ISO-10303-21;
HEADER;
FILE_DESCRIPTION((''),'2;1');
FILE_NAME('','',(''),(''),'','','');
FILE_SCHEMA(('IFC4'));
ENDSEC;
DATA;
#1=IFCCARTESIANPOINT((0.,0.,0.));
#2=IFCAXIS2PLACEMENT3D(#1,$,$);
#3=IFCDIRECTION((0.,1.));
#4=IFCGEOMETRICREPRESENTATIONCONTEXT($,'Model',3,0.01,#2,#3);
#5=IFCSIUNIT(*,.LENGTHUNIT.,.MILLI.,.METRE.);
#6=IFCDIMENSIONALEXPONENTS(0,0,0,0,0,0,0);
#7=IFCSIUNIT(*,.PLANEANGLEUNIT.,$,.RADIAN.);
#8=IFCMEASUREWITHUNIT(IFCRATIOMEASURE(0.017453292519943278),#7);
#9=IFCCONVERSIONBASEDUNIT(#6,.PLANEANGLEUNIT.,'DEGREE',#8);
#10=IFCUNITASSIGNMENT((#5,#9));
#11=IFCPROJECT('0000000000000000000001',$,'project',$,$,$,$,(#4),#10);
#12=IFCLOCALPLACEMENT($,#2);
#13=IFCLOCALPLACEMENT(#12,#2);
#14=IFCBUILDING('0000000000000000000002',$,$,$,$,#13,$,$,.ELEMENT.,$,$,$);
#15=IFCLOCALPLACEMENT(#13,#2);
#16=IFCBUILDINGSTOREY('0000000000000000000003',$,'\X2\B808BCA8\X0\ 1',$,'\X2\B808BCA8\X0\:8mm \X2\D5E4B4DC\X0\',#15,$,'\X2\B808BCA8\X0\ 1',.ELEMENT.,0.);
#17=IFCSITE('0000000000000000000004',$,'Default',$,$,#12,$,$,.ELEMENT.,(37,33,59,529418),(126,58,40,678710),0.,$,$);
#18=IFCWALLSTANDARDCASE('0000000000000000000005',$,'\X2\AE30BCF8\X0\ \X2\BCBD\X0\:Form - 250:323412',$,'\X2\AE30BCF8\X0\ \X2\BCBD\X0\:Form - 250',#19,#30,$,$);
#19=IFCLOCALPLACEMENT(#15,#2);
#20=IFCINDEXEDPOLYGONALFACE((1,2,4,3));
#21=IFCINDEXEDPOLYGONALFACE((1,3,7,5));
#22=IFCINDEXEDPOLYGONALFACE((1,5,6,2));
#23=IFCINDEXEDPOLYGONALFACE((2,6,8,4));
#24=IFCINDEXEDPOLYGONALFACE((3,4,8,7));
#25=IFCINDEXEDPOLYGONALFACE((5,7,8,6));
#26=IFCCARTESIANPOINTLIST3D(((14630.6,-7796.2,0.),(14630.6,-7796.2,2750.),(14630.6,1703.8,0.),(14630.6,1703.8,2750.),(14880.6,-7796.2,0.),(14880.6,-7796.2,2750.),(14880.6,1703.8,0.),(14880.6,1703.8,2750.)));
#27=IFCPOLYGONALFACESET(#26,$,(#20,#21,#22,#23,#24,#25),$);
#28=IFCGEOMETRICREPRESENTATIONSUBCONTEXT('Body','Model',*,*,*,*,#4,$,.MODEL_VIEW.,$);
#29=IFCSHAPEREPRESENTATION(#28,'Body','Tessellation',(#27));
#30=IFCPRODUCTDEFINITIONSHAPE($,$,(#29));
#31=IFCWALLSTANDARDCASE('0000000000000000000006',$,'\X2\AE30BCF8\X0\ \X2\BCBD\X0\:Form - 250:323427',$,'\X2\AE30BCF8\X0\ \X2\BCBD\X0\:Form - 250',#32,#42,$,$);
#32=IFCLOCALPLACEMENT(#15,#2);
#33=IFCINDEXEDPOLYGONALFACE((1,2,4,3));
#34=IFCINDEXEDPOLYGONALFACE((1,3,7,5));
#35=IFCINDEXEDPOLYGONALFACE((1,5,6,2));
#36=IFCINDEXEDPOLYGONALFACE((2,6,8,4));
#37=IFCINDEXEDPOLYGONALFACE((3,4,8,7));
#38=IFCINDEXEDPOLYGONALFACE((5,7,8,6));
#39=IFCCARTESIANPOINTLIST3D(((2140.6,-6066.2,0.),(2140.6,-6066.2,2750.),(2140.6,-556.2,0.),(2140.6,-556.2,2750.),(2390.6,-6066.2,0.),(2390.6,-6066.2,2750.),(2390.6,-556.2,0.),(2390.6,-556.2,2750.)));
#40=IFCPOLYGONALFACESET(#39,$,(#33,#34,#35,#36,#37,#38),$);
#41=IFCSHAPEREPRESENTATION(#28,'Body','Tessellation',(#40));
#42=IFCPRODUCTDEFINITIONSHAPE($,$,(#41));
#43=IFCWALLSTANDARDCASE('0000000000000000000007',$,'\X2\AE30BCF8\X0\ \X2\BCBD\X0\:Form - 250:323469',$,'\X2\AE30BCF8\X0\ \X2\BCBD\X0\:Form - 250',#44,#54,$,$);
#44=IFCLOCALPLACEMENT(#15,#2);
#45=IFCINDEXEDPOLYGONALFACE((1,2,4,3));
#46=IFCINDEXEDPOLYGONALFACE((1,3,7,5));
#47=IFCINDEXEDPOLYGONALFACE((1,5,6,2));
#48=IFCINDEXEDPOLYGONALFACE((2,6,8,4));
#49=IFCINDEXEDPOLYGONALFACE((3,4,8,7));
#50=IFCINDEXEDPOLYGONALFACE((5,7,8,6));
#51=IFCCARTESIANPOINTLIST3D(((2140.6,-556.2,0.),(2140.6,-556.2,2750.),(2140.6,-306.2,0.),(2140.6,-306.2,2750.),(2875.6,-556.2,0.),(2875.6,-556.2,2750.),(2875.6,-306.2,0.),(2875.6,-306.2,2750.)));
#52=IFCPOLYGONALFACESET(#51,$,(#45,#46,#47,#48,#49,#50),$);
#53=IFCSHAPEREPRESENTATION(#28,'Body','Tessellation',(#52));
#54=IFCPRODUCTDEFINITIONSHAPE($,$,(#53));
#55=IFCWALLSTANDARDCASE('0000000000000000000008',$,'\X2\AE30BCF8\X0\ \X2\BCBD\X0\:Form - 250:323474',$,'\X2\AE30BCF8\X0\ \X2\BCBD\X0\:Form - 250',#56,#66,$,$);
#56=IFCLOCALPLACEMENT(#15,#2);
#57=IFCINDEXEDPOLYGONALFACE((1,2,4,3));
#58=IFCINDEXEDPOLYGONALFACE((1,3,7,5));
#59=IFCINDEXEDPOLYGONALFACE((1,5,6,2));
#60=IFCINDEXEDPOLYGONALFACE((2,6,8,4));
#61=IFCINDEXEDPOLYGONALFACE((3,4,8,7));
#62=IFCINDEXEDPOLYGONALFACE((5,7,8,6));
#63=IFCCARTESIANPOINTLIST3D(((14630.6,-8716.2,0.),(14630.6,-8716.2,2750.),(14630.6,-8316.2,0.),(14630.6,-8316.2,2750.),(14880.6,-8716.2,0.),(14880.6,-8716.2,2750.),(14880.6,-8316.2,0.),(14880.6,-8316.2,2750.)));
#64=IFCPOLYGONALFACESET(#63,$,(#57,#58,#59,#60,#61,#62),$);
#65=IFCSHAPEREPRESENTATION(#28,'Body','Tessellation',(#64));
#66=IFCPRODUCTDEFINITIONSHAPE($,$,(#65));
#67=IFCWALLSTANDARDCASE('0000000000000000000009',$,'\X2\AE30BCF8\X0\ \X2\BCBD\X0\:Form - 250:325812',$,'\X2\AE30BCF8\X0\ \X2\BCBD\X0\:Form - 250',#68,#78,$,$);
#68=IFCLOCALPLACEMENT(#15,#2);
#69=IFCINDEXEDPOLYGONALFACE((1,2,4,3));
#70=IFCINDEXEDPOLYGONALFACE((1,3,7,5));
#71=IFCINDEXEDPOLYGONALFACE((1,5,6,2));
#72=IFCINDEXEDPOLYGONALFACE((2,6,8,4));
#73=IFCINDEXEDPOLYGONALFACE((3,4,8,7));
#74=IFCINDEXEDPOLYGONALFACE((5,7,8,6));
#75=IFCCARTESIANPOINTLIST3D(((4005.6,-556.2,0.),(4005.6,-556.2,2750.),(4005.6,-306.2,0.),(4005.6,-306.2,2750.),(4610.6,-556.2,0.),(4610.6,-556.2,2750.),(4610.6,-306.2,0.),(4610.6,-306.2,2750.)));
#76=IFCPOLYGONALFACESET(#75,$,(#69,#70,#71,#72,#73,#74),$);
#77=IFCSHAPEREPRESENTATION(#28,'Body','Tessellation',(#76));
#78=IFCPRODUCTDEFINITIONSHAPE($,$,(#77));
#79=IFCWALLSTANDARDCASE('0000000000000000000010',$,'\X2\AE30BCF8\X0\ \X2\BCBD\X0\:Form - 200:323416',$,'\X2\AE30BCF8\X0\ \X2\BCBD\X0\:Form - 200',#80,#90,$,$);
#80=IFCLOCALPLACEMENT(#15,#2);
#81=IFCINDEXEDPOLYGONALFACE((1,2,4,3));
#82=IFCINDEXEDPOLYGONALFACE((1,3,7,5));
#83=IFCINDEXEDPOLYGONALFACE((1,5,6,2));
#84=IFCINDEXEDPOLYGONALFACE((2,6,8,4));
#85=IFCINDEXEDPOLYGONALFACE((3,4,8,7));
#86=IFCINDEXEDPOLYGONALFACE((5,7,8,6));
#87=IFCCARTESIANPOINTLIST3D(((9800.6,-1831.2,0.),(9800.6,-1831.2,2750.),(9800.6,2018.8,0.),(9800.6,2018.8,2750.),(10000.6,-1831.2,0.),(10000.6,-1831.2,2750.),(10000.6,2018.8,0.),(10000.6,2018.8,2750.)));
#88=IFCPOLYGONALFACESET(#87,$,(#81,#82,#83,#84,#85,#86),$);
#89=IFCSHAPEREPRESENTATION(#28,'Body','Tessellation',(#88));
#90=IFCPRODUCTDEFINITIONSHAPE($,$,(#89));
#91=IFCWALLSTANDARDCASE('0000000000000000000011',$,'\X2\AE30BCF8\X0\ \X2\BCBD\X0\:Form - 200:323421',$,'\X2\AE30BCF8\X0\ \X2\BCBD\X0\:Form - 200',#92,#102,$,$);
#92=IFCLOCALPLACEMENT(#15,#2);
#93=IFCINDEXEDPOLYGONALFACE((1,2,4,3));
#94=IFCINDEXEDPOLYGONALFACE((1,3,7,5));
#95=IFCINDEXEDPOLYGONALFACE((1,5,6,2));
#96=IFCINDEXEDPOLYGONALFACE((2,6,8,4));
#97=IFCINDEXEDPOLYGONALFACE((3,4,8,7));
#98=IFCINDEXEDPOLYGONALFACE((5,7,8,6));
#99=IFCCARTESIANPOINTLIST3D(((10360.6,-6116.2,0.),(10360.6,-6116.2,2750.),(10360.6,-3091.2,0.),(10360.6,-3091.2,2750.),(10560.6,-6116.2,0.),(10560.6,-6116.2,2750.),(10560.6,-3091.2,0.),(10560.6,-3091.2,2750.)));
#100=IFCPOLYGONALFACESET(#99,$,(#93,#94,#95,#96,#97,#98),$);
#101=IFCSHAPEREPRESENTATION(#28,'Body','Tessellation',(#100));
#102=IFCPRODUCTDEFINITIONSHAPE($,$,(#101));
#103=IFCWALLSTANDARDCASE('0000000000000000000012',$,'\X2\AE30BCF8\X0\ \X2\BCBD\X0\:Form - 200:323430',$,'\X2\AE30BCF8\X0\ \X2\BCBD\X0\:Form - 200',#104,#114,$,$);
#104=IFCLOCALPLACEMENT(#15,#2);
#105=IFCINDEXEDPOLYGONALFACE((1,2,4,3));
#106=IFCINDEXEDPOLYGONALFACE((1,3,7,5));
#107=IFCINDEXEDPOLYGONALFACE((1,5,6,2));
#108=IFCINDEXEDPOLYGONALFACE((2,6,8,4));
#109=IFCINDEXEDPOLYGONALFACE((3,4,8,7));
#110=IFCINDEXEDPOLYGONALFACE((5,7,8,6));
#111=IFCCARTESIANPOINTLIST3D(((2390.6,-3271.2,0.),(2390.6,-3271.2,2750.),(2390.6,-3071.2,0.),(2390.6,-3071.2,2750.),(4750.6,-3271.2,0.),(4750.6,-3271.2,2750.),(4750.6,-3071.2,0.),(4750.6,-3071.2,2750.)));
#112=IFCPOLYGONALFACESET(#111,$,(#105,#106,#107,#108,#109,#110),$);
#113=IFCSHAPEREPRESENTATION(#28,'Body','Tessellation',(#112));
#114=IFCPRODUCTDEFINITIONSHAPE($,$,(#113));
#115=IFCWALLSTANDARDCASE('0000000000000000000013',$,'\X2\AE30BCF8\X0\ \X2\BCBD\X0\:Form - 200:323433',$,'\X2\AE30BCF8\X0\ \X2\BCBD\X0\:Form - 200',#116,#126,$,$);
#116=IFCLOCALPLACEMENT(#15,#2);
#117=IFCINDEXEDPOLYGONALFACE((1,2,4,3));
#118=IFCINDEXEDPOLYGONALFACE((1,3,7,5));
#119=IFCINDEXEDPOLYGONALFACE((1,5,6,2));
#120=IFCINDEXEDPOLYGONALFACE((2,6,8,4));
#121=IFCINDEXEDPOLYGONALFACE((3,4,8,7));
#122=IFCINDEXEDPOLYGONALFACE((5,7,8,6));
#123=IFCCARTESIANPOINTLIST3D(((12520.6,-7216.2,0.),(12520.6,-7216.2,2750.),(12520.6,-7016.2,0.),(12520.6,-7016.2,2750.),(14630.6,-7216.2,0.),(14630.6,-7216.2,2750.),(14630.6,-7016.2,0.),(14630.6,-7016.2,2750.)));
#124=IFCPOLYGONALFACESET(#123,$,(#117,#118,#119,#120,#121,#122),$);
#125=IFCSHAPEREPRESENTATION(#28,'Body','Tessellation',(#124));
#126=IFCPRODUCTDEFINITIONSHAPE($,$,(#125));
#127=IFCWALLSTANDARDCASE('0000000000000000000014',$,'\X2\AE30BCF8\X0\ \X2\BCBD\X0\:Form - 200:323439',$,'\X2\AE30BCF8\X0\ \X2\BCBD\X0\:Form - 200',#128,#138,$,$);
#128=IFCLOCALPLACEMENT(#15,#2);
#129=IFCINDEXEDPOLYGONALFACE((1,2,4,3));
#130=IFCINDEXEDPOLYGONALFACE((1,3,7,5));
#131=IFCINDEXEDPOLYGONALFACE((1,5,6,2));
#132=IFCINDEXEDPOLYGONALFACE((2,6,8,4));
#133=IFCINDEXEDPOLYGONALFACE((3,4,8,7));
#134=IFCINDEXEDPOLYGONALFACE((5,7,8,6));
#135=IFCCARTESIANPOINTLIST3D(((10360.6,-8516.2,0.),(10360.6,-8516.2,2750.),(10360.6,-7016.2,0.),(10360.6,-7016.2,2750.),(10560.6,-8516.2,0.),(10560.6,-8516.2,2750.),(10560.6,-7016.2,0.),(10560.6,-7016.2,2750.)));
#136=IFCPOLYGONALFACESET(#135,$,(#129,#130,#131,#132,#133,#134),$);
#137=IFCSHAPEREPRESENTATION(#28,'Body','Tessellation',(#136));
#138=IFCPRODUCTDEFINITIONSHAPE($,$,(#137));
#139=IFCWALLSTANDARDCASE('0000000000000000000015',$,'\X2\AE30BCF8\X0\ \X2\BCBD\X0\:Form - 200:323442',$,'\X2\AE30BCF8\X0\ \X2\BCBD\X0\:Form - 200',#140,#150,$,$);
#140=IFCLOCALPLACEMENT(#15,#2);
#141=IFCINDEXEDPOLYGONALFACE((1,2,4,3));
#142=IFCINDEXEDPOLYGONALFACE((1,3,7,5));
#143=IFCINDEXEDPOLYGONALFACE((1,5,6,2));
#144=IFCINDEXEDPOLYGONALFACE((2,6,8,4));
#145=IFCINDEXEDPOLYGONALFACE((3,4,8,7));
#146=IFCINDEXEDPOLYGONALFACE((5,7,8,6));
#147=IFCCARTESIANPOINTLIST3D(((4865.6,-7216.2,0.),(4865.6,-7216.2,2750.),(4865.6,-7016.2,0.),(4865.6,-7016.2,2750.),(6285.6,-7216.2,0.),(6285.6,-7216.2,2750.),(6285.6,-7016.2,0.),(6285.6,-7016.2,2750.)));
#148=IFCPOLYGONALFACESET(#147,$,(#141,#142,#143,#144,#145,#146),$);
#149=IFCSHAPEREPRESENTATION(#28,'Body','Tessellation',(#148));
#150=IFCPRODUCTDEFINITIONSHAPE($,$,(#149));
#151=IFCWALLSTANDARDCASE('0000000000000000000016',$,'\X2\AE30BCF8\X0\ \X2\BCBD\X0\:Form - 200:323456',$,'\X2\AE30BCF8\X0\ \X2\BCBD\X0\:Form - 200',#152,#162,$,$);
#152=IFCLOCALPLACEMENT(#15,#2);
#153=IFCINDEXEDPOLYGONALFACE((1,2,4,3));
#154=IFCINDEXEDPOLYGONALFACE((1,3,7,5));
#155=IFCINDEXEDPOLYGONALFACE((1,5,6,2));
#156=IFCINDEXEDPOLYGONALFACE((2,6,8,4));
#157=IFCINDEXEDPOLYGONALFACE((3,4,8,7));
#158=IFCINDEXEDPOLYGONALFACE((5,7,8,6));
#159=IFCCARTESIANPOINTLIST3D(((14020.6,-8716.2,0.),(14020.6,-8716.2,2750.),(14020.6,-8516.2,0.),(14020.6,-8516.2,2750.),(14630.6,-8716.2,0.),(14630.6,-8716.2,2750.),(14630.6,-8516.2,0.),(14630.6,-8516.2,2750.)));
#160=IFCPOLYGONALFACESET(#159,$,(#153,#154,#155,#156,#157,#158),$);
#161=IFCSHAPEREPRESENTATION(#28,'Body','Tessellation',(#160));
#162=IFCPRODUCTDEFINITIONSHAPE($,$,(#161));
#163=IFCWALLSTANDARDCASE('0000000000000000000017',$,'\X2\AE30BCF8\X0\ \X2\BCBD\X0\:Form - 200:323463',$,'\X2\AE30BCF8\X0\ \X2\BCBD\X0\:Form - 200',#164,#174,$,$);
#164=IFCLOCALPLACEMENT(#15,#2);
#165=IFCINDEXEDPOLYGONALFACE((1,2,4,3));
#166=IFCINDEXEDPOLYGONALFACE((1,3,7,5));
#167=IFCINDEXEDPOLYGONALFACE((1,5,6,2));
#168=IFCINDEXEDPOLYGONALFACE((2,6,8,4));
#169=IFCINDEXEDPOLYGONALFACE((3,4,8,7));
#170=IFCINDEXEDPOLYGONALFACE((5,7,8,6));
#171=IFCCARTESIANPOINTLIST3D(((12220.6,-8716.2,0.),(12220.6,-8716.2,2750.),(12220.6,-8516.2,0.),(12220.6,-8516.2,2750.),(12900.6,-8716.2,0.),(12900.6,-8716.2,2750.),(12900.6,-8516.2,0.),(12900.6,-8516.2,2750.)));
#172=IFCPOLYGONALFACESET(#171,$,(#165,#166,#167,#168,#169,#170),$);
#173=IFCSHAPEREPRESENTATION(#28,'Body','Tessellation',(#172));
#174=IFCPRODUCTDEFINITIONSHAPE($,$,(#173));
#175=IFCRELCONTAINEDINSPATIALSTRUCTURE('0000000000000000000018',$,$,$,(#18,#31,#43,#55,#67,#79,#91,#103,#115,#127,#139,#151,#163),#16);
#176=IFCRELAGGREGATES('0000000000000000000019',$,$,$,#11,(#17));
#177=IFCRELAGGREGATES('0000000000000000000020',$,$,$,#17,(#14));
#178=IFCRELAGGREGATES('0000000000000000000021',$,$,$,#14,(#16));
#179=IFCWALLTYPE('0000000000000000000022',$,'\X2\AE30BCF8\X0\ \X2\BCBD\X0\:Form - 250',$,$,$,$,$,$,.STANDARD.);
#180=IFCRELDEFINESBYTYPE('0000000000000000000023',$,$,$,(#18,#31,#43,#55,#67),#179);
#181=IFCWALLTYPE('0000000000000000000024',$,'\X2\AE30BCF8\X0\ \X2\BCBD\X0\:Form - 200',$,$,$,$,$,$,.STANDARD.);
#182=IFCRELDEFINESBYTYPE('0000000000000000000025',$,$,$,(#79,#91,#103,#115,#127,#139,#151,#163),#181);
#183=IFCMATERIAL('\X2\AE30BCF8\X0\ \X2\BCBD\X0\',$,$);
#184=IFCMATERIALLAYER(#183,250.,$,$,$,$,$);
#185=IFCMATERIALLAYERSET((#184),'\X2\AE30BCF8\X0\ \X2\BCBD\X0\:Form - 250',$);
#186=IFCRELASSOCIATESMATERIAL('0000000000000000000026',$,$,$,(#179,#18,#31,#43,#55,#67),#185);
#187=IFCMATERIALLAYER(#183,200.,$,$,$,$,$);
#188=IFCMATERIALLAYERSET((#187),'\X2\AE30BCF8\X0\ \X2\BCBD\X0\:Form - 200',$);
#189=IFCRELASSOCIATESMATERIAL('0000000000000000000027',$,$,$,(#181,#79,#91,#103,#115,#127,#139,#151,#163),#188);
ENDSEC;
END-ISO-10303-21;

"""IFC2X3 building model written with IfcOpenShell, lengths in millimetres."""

from ifc_helpers import new_model, entity, si_unit, converted_unit, direction, frame, frame_2d, origin, place, context, subcontext, project, spatial, rectangle, extrude, material, layer, layer_set, layer_usage, type_object, element, save


model = new_model("IFC2X3")

# Units and contexts
model_context = context("Model", 3, precision=0.01, world=origin(), true_north=direction((0.0, 1.0)))
body_context = subcontext(model_context, "Body", "Model", "MODEL_VIEW")
ifc_project = project(units=[si_unit("LENGTHUNIT", "METRE", prefix="MILLI"), converted_unit("PLANEANGLEUNIT", "DEGREE", entity("IfcRatioMeasure", 0.017453292519943278), si_unit("PLANEANGLEUNIT", "RADIAN"), dimensions=[0, 0, 0, 0, 0, 0, 0])], contexts=[model_context])

# Site, building, storey
site_placement = place(None, origin())
site = spatial("IfcSite", under=ifc_project, at=site_placement, Name="Default", CompositionType="ELEMENT", RefLatitude=(37, 33, 59, 529418), RefLongitude=(126, 58, 40, 678710), RefElevation=0.0)
building_placement = place(site_placement, origin())
building = spatial("IfcBuilding", under=site, at=building_placement, CompositionType="ELEMENT")
storey_placement = place(building_placement, origin())
storey = spatial("IfcBuildingStorey", under=building, at=storey_placement, Name="레벨 1", ObjectType="레벨:8mm 헤드", LongName="레벨 1", CompositionType="ELEMENT", Elevation=0.0)

# Walls
ifc_material_1 = material(Name="기본 벽")
ifc_layer_1 = layer(ifc_material_1, 250.0)
ifc_layer_set_1 = layer_set([ifc_layer_1], Name="기본 벽:Form - 250")
ifc_layer_usage_1 = layer_usage(ifc_layer_set_1, "AXIS2", "POSITIVE", -125.0)
wall_type_1 = type_object("IfcWallType", Name="기본 벽:Form - 250", PredefinedType="STANDARD", material=ifc_layer_set_1)
wall_1_placement = place(storey_placement, frame((14755.6, -7796.2, 0.0), z_axis=(0.0, 0.0, 1.0), x_axis=(0.0, 1.0, 0.0)))
element("IfcWallStandardCase", 1, at=wall_1_placement, inside=storey, type_object=wall_type_1, material=ifc_layer_usage_1, Name="기본 벽:Form - 250:323412", ObjectType="기본 벽:Form - 250", context=body_context, shape_type="SweptSolid", body=[
    extrude(rectangle(XDim=9500.0, YDim=250.0, at=frame_2d((4750.0, 0.0), x_axis=(-1.0, 0.0))), origin(), (0.0, 0.0, 1.0), 2750.0),
])
ifc_layer_usage_2 = layer_usage(ifc_layer_set_1, "AXIS2", "POSITIVE", -125.0)
wall_2_placement = place(storey_placement, frame((2265.6, -556.2, 0.0), z_axis=(0.0, 0.0, 1.0), x_axis=(0.0, -1.0, 0.0)))
element("IfcWallStandardCase", 2, at=wall_2_placement, inside=storey, type_object=wall_type_1, material=ifc_layer_usage_2, Name="기본 벽:Form - 250:323427", ObjectType="기본 벽:Form - 250", context=body_context, shape_type="SweptSolid", body=[
    extrude(rectangle(XDim=5510.0, YDim=250.0, at=frame_2d((2755.0, 0.0), x_axis=(-1.0, 0.0))), origin(), (0.0, 0.0, 1.0), 2750.0),
])
ifc_layer_usage_3 = layer_usage(ifc_layer_set_1, "AXIS2", "POSITIVE", -125.0)
wall_3_placement = place(storey_placement, frame((2140.6, -431.2, 0.0)))
element("IfcWallStandardCase", 3, at=wall_3_placement, inside=storey, type_object=wall_type_1, material=ifc_layer_usage_3, Name="기본 벽:Form - 250:323469", ObjectType="기본 벽:Form - 250", context=body_context, shape_type="SweptSolid", body=[
    extrude(rectangle(XDim=735.0, YDim=250.0, at=frame_2d((367.5, 0.0), x_axis=(-1.0, 0.0))), origin(), (0.0, 0.0, 1.0), 2750.0),
])
ifc_layer_usage_4 = layer_usage(ifc_layer_set_1, "AXIS2", "POSITIVE", -125.0)
wall_4_placement = place(storey_placement, frame((14755.6, -8316.2, 0.0), z_axis=(0.0, 0.0, 1.0), x_axis=(0.0, -1.0, 0.0)))
element("IfcWallStandardCase", 4, at=wall_4_placement, inside=storey, type_object=wall_type_1, material=ifc_layer_usage_4, Name="기본 벽:Form - 250:323474", ObjectType="기본 벽:Form - 250", context=body_context, shape_type="SweptSolid", body=[
    extrude(rectangle(XDim=400.0, YDim=250.0, at=frame_2d((200.0, 0.0), x_axis=(-1.0, 0.0))), origin(), (0.0, 0.0, 1.0), 2750.0),
])
ifc_layer_usage_5 = layer_usage(ifc_layer_set_1, "AXIS2", "POSITIVE", -125.0)
wall_5_placement = place(storey_placement, frame((4005.6, -431.2, 0.0)))
element("IfcWallStandardCase", 5, at=wall_5_placement, inside=storey, type_object=wall_type_1, material=ifc_layer_usage_5, Name="기본 벽:Form - 250:325812", ObjectType="기본 벽:Form - 250", context=body_context, shape_type="SweptSolid", body=[
    extrude(rectangle(XDim=605.0, YDim=250.0, at=frame_2d((302.5, 0.0), x_axis=(-1.0, 0.0))), origin(), (0.0, 0.0, 1.0), 2750.0),
])
ifc_layer_2 = layer(ifc_material_1, 200.0)
ifc_layer_set_2 = layer_set([ifc_layer_2], Name="기본 벽:Form - 200")
ifc_layer_usage_6 = layer_usage(ifc_layer_set_2, "AXIS2", "POSITIVE", -100.0)
wall_type_2 = type_object("IfcWallType", Name="기본 벽:Form - 200", PredefinedType="STANDARD", material=ifc_layer_set_2)
wall_6_placement = place(storey_placement, frame((9900.6, -1831.2, 0.0), z_axis=(0.0, 0.0, 1.0), x_axis=(0.0, 1.0, 0.0)))
element("IfcWallStandardCase", 6, at=wall_6_placement, inside=storey, type_object=wall_type_2, material=ifc_layer_usage_6, Name="기본 벽:Form - 200:323416", ObjectType="기본 벽:Form - 200", context=body_context, shape_type="SweptSolid", body=[
    extrude(rectangle(XDim=3850.0, YDim=200.0, at=frame_2d((1925.0, 0.0), x_axis=(-1.0, 0.0))), origin(), (0.0, 0.0, 1.0), 2750.0),
])
ifc_layer_usage_7 = layer_usage(ifc_layer_set_2, "AXIS2", "POSITIVE", -100.0)
wall_7_placement = place(storey_placement, frame((10460.6, -6116.2, 0.0), z_axis=(0.0, 0.0, 1.0), x_axis=(0.0, 1.0, 0.0)))
element("IfcWallStandardCase", 7, at=wall_7_placement, inside=storey, type_object=wall_type_2, material=ifc_layer_usage_7, Name="기본 벽:Form - 200:323421", ObjectType="기본 벽:Form - 200", context=body_context, shape_type="SweptSolid", body=[
    extrude(rectangle(XDim=3025.0, YDim=200.0, at=frame_2d((1512.5, 0.0), x_axis=(-1.0, 0.0))), origin(), (0.0, 0.0, 1.0), 2750.0),
])
ifc_layer_usage_8 = layer_usage(ifc_layer_set_2, "AXIS2", "POSITIVE", -100.0)
wall_8_placement = place(storey_placement, frame((2390.6, -3171.2, 0.0)))
element("IfcWallStandardCase", 8, at=wall_8_placement, inside=storey, type_object=wall_type_2, material=ifc_layer_usage_8, Name="기본 벽:Form - 200:323430", ObjectType="기본 벽:Form - 200", context=body_context, shape_type="SweptSolid", body=[
    extrude(rectangle(XDim=2360.0, YDim=200.0, at=frame_2d((1180.0, 0.0), x_axis=(-1.0, 0.0))), origin(), (0.0, 0.0, 1.0), 2750.0),
])
ifc_layer_usage_9 = layer_usage(ifc_layer_set_2, "AXIS2", "POSITIVE", -100.0)
wall_9_placement = place(storey_placement, frame((12520.6, -7116.2, 0.0)))
element("IfcWallStandardCase", 9, at=wall_9_placement, inside=storey, type_object=wall_type_2, material=ifc_layer_usage_9, Name="기본 벽:Form - 200:323433", ObjectType="기본 벽:Form - 200", context=body_context, shape_type="SweptSolid", body=[
    extrude(rectangle(XDim=2110.0, YDim=200.0, at=frame_2d((1055.0, 0.0), x_axis=(-1.0, 0.0))), origin(), (0.0, 0.0, 1.0), 2750.0),
])
ifc_layer_usage_10 = layer_usage(ifc_layer_set_2, "AXIS2", "POSITIVE", -100.0)
wall_10_placement = place(storey_placement, frame((10460.6, -8516.2, 0.0), z_axis=(0.0, 0.0, 1.0), x_axis=(0.0, 1.0, 0.0)))
element("IfcWallStandardCase", 10, at=wall_10_placement, inside=storey, type_object=wall_type_2, material=ifc_layer_usage_10, Name="기본 벽:Form - 200:323439", ObjectType="기본 벽:Form - 200", context=body_context, shape_type="SweptSolid", body=[
    extrude(rectangle(XDim=1500.0, YDim=200.0, at=frame_2d((750.0, 0.0), x_axis=(-1.0, 0.0))), origin(), (0.0, 0.0, 1.0), 2750.0),
])
ifc_layer_usage_11 = layer_usage(ifc_layer_set_2, "AXIS2", "POSITIVE", -100.0)
wall_11_placement = place(storey_placement, frame((6285.6, -7116.2, 0.0), z_axis=(0.0, 0.0, 1.0), x_axis=(-1.0, 0.0, 0.0)))
element("IfcWallStandardCase", 11, at=wall_11_placement, inside=storey, type_object=wall_type_2, material=ifc_layer_usage_11, Name="기본 벽:Form - 200:323442", ObjectType="기본 벽:Form - 200", context=body_context, shape_type="SweptSolid", body=[
    extrude(rectangle(XDim=1420.0, YDim=200.0, at=frame_2d((710.0, 0.0), x_axis=(-1.0, 0.0))), origin(), (0.0, 0.0, 1.0), 2750.0),
])
ifc_layer_usage_12 = layer_usage(ifc_layer_set_2, "AXIS2", "POSITIVE", -100.0)
wall_12_placement = place(storey_placement, frame((14630.6, -8616.2, 0.0), z_axis=(0.0, 0.0, 1.0), x_axis=(-1.0, 0.0, 0.0)))
element("IfcWallStandardCase", 12, at=wall_12_placement, inside=storey, type_object=wall_type_2, material=ifc_layer_usage_12, Name="기본 벽:Form - 200:323456", ObjectType="기본 벽:Form - 200", context=body_context, shape_type="SweptSolid", body=[
    extrude(rectangle(XDim=610.0, YDim=200.0, at=frame_2d((305.0, 0.0), x_axis=(-1.0, 0.0))), origin(), (0.0, 0.0, 1.0), 2750.0),
])
ifc_layer_usage_13 = layer_usage(ifc_layer_set_2, "AXIS2", "POSITIVE", -100.0)
wall_13_placement = place(storey_placement, frame((12220.6, -8616.2, 0.0)))
element("IfcWallStandardCase", 13, at=wall_13_placement, inside=storey, type_object=wall_type_2, material=ifc_layer_usage_13, Name="기본 벽:Form - 200:323463", ObjectType="기본 벽:Form - 200", context=body_context, shape_type="SweptSolid", body=[
    extrude(rectangle(XDim=680.0, YDim=200.0, at=frame_2d((340.0, 0.0), x_axis=(-1.0, 0.0))), origin(), (0.0, 0.0, 1.0), 2750.0),
])

save(model, "model.ifc")
